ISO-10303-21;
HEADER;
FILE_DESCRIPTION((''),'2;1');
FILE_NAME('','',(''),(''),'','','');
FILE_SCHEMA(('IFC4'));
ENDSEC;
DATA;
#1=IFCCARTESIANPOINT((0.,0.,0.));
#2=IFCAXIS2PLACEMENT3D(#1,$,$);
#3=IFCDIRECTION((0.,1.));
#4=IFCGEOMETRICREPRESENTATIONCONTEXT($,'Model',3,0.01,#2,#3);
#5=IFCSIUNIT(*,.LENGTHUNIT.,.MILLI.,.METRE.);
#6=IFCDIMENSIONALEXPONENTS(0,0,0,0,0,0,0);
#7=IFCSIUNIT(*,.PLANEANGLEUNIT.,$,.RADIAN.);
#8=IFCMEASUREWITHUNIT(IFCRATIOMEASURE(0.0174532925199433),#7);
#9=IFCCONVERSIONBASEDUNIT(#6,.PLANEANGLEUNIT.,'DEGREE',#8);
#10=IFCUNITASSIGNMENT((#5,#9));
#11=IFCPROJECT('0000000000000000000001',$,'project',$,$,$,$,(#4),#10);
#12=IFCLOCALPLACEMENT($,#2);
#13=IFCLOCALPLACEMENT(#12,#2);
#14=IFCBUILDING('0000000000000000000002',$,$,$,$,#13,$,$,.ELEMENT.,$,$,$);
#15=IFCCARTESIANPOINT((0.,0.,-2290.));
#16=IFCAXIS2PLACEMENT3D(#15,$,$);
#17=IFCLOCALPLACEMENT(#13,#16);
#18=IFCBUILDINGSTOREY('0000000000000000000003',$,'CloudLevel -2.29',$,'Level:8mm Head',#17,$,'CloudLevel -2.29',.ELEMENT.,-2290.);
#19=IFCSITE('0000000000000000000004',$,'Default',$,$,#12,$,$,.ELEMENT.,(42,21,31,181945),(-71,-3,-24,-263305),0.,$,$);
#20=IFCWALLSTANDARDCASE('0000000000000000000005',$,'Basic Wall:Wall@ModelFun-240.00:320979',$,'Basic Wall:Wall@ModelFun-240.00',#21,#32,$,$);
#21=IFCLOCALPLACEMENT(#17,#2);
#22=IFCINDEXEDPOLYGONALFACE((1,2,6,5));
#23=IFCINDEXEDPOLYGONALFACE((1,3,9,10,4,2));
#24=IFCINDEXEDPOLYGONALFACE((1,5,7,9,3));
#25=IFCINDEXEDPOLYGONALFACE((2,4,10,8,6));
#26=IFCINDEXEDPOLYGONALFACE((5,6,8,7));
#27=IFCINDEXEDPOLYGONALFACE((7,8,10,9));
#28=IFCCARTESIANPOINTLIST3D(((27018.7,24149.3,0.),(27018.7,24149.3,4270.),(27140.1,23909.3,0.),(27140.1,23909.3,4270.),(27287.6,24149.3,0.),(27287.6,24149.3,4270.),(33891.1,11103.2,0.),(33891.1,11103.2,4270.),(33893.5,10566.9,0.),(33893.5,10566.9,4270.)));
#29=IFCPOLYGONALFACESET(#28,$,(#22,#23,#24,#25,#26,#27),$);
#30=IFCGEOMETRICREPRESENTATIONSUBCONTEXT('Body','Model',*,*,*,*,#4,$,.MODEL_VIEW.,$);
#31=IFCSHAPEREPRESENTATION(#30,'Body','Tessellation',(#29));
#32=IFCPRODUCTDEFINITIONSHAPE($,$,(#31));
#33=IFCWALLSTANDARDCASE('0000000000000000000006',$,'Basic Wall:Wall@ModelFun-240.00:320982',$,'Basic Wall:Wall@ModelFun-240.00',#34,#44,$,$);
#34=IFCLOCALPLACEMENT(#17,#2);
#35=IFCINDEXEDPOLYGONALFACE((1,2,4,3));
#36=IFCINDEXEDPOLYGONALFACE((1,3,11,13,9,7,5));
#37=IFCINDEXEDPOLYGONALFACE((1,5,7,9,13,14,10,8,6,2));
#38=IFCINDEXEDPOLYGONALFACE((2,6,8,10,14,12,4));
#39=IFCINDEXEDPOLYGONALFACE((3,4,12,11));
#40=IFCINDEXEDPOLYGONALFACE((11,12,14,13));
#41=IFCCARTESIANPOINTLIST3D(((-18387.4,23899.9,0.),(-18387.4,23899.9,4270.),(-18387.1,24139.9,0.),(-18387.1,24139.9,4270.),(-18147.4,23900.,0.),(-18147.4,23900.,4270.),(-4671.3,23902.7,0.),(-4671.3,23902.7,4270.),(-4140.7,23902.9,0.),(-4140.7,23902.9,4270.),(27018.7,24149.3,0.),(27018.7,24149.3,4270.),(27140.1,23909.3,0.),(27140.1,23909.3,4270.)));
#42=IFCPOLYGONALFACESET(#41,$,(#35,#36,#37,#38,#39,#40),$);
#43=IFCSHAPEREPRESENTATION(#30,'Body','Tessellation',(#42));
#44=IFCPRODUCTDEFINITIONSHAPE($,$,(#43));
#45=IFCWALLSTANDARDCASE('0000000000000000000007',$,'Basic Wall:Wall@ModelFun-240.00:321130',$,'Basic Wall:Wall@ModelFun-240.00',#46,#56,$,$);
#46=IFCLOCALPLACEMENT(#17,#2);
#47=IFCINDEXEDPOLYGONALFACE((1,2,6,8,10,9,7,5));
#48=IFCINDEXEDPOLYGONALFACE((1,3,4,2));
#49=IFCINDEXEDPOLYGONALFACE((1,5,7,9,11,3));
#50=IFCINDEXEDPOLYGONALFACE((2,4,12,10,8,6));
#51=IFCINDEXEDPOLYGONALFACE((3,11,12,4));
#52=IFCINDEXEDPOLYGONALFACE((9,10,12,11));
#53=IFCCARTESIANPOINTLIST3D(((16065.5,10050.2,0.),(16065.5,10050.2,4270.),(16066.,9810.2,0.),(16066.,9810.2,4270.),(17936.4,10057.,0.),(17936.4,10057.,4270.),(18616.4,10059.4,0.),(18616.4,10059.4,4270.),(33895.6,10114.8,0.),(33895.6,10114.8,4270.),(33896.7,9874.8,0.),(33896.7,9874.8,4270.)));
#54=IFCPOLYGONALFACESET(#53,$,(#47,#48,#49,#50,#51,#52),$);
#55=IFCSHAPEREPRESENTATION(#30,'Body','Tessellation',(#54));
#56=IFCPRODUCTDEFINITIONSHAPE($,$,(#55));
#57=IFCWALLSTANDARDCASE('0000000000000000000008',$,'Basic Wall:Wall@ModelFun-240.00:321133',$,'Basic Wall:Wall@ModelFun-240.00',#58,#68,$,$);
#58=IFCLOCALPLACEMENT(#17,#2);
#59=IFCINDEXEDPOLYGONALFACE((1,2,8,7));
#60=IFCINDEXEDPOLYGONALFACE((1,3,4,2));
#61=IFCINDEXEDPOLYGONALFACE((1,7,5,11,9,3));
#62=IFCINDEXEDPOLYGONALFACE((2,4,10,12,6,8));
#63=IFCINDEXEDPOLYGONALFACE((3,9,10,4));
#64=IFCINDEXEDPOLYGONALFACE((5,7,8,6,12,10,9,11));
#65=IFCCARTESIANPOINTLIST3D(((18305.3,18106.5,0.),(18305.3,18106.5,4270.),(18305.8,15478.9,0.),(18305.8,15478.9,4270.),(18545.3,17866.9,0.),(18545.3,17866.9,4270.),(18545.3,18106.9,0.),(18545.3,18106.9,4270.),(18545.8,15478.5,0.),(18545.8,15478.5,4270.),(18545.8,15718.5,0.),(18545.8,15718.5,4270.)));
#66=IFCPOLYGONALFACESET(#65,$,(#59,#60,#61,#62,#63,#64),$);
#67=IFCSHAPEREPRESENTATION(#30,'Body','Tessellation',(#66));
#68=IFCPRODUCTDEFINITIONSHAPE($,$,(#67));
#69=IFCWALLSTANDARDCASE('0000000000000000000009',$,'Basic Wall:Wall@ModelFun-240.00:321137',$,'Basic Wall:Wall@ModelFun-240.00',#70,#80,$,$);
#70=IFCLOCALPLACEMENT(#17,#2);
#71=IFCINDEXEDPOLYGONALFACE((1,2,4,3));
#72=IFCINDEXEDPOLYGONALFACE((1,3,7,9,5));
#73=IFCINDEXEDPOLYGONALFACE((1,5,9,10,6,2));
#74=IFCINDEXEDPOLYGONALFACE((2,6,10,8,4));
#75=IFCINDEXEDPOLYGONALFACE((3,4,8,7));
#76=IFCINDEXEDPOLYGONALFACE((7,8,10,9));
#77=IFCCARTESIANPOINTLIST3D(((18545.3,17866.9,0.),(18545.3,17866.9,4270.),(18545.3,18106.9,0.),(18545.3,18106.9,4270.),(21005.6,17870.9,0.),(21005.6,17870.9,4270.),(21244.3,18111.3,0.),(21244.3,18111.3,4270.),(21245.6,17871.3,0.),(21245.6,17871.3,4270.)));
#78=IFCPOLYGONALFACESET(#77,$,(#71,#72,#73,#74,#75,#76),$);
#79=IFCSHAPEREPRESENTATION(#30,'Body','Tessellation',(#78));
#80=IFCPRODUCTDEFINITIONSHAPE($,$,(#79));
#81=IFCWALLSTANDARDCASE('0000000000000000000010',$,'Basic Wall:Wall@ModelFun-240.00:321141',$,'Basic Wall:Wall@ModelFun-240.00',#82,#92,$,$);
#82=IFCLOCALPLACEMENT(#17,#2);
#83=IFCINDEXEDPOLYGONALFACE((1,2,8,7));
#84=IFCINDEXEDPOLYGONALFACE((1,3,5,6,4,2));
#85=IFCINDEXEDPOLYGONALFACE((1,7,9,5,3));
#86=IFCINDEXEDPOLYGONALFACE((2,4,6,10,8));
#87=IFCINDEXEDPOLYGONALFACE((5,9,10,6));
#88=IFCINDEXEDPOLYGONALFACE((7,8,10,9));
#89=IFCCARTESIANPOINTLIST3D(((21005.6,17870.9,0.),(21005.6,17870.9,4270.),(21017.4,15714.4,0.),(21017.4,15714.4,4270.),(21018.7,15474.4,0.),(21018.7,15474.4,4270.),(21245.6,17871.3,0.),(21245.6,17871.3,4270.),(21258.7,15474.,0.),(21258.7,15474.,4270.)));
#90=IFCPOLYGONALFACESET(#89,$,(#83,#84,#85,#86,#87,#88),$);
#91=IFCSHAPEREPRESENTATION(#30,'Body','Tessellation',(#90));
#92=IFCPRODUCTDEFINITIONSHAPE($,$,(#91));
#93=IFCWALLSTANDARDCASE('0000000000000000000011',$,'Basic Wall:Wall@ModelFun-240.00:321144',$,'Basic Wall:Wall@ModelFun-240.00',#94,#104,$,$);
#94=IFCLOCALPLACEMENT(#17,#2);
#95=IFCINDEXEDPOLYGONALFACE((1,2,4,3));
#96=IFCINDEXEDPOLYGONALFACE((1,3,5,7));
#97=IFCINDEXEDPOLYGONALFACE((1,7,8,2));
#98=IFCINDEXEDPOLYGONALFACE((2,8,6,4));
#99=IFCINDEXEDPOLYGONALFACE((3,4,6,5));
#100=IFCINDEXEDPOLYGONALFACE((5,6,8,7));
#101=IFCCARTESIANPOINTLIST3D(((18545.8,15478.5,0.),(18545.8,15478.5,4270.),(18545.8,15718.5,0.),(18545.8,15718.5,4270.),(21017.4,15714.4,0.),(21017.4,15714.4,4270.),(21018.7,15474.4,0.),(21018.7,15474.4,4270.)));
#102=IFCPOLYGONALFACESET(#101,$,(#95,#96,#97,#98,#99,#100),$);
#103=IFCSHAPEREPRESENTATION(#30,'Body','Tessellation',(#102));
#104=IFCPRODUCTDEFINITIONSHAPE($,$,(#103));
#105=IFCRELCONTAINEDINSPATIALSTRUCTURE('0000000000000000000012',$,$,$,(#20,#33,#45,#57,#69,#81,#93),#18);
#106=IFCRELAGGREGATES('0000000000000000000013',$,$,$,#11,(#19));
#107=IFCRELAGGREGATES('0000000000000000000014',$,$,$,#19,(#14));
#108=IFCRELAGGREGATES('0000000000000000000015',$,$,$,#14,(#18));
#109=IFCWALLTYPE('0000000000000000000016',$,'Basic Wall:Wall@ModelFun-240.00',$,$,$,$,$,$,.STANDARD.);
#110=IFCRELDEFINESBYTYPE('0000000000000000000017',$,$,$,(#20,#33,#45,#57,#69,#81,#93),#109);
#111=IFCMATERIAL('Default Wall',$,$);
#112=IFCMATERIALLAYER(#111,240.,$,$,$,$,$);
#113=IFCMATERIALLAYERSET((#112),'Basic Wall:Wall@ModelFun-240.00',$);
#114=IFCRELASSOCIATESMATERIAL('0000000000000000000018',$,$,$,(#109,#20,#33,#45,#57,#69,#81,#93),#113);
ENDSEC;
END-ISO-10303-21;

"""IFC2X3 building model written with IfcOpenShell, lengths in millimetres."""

from ifc_helpers import new_model, entity, si_unit, converted_unit, direction, frame, origin, place, context, subcontext, project, spatial, polyline, outline, extrude, material, layer, layer_set, layer_usage, type_object, element, save


model = new_model("IFC2X3")

# Units and contexts
model_context = context("Model", 3, precision=0.01, world=origin(), true_north=direction((0.0, 1.0)))
body_context = subcontext(model_context, "Body", "Model", "MODEL_VIEW")
ifc_project = project(units=[si_unit("LENGTHUNIT", "METRE", prefix="MILLI"), converted_unit("PLANEANGLEUNIT", "DEGREE", entity("IfcRatioMeasure", 0.0174532925199433), si_unit("PLANEANGLEUNIT", "RADIAN"), dimensions=[0, 0, 0, 0, 0, 0, 0])], contexts=[model_context])

# Site, building, storey
site_placement = place(None, origin())
site = spatial("IfcSite", under=ifc_project, at=site_placement, Name="Default", CompositionType="ELEMENT", RefLatitude=(42, 21, 31, 181945), RefLongitude=(-71, -3, -24, -263305), RefElevation=0.0)
building_placement = place(site_placement, origin())
building = spatial("IfcBuilding", under=site, at=building_placement, CompositionType="ELEMENT")
storey_placement = place(building_placement, frame((0.0, 0.0, -2290.0)))
storey = spatial("IfcBuildingStorey", under=building, at=storey_placement, Name="CloudLevel -2.29", ObjectType="Level:8mm Head", LongName="CloudLevel -2.29", CompositionType="ELEMENT", Elevation=-2290.0)

# Walls
ifc_material_1 = material(Name="Default Wall")
ifc_layer_1 = layer(ifc_material_1, 240.0)
ifc_layer_set_1 = layer_set([ifc_layer_1], Name="Basic Wall:Wall@ModelFun-240.00")
ifc_layer_usage_1 = layer_usage(ifc_layer_set_1, "AXIS2", "NEGATIVE", 120.0)
wall_type_1 = type_object("IfcWallType", Name="Basic Wall:Wall@ModelFun-240.00", PredefinedType="STANDARD", material=ifc_layer_set_1)
wall_1_placement = place(storey_placement, frame((27125.7, 24203.4, 0.0), z_axis=(0.0, 0.0, 1.0), x_axis=(0.451605, -0.892218, 0.0)))
element("IfcWallStandardCase", 1, at=wall_1_placement, inside=storey, type_object=wall_type_1, material=ifc_layer_usage_1, Name="Basic Wall:Wall@ModelFun-240.00:320979", ObjectType="Basic Wall:Wall@ModelFun-240.00", context=body_context, shape_type="SweptSolid", body=[
    extrude(outline(polyline([(15223.1, -120.0), (14743.6, 120.0), (121.4, 120.0), (0.0, -120.0), (269.0, -120.0), (15223.1, -120.0)])), origin(), (0.0, 0.0, 1.0), 4270.0),
])
ifc_layer_usage_2 = layer_usage(ifc_layer_set_1, "AXIS2", "NEGATIVE", 120.0)
wall_2_placement = place(storey_placement, frame((27140.1, 24029.3, 0.0), z_axis=(0.0, 0.0, 1.0), x_axis=(-1.0, -0.000205, 0.0)))
element("IfcWallStandardCase", 2, at=wall_2_placement, inside=storey, type_object=wall_type_1, material=ifc_layer_usage_2, Name="Basic Wall:Wall@ModelFun-240.00:320982", ObjectType="Basic Wall:Wall@ModelFun-240.00", context=body_context, shape_type="SweptSolid", body=[
    extrude(outline(polyline([(45527.2, -120.0), (45527.5, 120.0), (45287.5, 120.0), (31811.4, 120.0), (31280.8, 120.0), (0.0, 120.0), (121.4, -120.0), (45527.2, -120.0)])), origin(), (0.0, 0.0, 1.0), 4270.0),
])
ifc_layer_usage_3 = layer_usage(ifc_layer_set_1, "AXIS2", "NEGATIVE", 120.0)
wall_3_placement = place(storey_placement, frame((33896.2, 9994.8, 0.0), z_axis=(0.0, 0.0, 1.0), x_axis=(-0.999993, -0.003624, 0.0)))
element("IfcWallStandardCase", 3, at=wall_3_placement, inside=storey, type_object=wall_type_1, material=ifc_layer_usage_3, Name="Basic Wall:Wall@ModelFun-240.00:321130", ObjectType="Basic Wall:Wall@ModelFun-240.00", context=body_context, shape_type="SweptSolid", body=[
    extrude(outline(polyline([(17830.4, -120.0), (17830.8, 120.0), (0.0, 120.0), (0.2, -120.0), (15279.5, -120.0), (15959.5, -120.0), (17830.4, -120.0)])), origin(), (0.0, 0.0, 1.0), 4270.0),
])
ifc_layer_usage_4 = layer_usage(ifc_layer_set_1, "AXIS2", "NEGATIVE", 120.0)
wall_4_placement = place(storey_placement, frame((18425.3, 18106.9, 0.0), z_axis=(0.0, 0.0, 1.0), x_axis=(0.000208, -1.0, 0.0)))
element("IfcWallStandardCase", 4, at=wall_4_placement, inside=storey, type_object=wall_type_1, material=ifc_layer_usage_4, Name="Basic Wall:Wall@ModelFun-240.00:321133", ObjectType="Basic Wall:Wall@ModelFun-240.00", context=body_context, shape_type="SweptSolid", body=[
    extrude(outline(polyline([(2627.9, -120.0), (2628.4, 120.0), (2388.4, 120.0), (240.0, 120.0), (0.0, 120.0), (0.3, -120.0), (2627.9, -120.0)])), origin(), (0.0, 0.0, 1.0), 4270.0),
])
ifc_layer_usage_5 = layer_usage(ifc_layer_set_1, "AXIS2", "NEGATIVE", 120.0)
wall_5_placement = place(storey_placement, frame((21245.4, 17991.3, 0.0), z_axis=(0.0, 0.0, 1.0), x_axis=(-0.999999, -0.001607, 0.0)))
element("IfcWallStandardCase", 5, at=wall_5_placement, inside=storey, type_object=wall_type_1, material=ifc_layer_usage_5, Name="Basic Wall:Wall@ModelFun-240.00:321137", ObjectType="Basic Wall:Wall@ModelFun-240.00", context=body_context, shape_type="SweptSolid", body=[
    extrude(outline(polyline([(2699.9, -120.0), (2700.3, 120.0), (240.0, 120.0), (0.0, 120.0), (0.9, -120.0), (2699.9, -120.0)])), origin(), (0.0, 0.0, 1.0), 4270.0),
])
ifc_layer_usage_6 = layer_usage(ifc_layer_set_1, "AXIS2", "NEGATIVE", 120.0)
wall_6_placement = place(storey_placement, frame((21138.7, 15473.4, 0.0), z_axis=(0.0, 0.0, 1.0), x_axis=(-0.005462, 0.999985, 0.0)))
element("IfcWallStandardCase", 6, at=wall_6_placement, inside=storey, type_object=wall_type_1, material=ifc_layer_usage_6, Name="Basic Wall:Wall@ModelFun-240.00:321141", ObjectType="Basic Wall:Wall@ModelFun-240.00", context=body_context, shape_type="SweptSolid", body=[
    extrude(outline(polyline([(2397.3, -120.0), (2398.2, 120.0), (241.7, 120.0), (1.7, 120.0), (0.0, -120.0), (2397.3, -120.0)])), origin(), (0.0, 0.0, 1.0), 4270.0),
])
ifc_layer_usage_7 = layer_usage(ifc_layer_set_1, "AXIS2", "NEGATIVE", 120.0)
wall_7_placement = place(storey_placement, frame((18545.6, 15598.5, 0.0), z_axis=(0.0, 0.0, 1.0), x_axis=(0.999999, -0.00167, 0.0)))
element("IfcWallStandardCase", 7, at=wall_7_placement, inside=storey, type_object=wall_type_1, material=ifc_layer_usage_7, Name="Basic Wall:Wall@ModelFun-240.00:321144", ObjectType="Basic Wall:Wall@ModelFun-240.00", context=body_context, shape_type="SweptSolid", body=[
    extrude(outline(polyline([(2473.3, -120.0), (2471.6, 120.0), (0.0, 120.0), (0.5, -120.0), (2473.3, -120.0)])), origin(), (0.0, 0.0, 1.0), 4270.0),
])

save(model, "model.ifc")
